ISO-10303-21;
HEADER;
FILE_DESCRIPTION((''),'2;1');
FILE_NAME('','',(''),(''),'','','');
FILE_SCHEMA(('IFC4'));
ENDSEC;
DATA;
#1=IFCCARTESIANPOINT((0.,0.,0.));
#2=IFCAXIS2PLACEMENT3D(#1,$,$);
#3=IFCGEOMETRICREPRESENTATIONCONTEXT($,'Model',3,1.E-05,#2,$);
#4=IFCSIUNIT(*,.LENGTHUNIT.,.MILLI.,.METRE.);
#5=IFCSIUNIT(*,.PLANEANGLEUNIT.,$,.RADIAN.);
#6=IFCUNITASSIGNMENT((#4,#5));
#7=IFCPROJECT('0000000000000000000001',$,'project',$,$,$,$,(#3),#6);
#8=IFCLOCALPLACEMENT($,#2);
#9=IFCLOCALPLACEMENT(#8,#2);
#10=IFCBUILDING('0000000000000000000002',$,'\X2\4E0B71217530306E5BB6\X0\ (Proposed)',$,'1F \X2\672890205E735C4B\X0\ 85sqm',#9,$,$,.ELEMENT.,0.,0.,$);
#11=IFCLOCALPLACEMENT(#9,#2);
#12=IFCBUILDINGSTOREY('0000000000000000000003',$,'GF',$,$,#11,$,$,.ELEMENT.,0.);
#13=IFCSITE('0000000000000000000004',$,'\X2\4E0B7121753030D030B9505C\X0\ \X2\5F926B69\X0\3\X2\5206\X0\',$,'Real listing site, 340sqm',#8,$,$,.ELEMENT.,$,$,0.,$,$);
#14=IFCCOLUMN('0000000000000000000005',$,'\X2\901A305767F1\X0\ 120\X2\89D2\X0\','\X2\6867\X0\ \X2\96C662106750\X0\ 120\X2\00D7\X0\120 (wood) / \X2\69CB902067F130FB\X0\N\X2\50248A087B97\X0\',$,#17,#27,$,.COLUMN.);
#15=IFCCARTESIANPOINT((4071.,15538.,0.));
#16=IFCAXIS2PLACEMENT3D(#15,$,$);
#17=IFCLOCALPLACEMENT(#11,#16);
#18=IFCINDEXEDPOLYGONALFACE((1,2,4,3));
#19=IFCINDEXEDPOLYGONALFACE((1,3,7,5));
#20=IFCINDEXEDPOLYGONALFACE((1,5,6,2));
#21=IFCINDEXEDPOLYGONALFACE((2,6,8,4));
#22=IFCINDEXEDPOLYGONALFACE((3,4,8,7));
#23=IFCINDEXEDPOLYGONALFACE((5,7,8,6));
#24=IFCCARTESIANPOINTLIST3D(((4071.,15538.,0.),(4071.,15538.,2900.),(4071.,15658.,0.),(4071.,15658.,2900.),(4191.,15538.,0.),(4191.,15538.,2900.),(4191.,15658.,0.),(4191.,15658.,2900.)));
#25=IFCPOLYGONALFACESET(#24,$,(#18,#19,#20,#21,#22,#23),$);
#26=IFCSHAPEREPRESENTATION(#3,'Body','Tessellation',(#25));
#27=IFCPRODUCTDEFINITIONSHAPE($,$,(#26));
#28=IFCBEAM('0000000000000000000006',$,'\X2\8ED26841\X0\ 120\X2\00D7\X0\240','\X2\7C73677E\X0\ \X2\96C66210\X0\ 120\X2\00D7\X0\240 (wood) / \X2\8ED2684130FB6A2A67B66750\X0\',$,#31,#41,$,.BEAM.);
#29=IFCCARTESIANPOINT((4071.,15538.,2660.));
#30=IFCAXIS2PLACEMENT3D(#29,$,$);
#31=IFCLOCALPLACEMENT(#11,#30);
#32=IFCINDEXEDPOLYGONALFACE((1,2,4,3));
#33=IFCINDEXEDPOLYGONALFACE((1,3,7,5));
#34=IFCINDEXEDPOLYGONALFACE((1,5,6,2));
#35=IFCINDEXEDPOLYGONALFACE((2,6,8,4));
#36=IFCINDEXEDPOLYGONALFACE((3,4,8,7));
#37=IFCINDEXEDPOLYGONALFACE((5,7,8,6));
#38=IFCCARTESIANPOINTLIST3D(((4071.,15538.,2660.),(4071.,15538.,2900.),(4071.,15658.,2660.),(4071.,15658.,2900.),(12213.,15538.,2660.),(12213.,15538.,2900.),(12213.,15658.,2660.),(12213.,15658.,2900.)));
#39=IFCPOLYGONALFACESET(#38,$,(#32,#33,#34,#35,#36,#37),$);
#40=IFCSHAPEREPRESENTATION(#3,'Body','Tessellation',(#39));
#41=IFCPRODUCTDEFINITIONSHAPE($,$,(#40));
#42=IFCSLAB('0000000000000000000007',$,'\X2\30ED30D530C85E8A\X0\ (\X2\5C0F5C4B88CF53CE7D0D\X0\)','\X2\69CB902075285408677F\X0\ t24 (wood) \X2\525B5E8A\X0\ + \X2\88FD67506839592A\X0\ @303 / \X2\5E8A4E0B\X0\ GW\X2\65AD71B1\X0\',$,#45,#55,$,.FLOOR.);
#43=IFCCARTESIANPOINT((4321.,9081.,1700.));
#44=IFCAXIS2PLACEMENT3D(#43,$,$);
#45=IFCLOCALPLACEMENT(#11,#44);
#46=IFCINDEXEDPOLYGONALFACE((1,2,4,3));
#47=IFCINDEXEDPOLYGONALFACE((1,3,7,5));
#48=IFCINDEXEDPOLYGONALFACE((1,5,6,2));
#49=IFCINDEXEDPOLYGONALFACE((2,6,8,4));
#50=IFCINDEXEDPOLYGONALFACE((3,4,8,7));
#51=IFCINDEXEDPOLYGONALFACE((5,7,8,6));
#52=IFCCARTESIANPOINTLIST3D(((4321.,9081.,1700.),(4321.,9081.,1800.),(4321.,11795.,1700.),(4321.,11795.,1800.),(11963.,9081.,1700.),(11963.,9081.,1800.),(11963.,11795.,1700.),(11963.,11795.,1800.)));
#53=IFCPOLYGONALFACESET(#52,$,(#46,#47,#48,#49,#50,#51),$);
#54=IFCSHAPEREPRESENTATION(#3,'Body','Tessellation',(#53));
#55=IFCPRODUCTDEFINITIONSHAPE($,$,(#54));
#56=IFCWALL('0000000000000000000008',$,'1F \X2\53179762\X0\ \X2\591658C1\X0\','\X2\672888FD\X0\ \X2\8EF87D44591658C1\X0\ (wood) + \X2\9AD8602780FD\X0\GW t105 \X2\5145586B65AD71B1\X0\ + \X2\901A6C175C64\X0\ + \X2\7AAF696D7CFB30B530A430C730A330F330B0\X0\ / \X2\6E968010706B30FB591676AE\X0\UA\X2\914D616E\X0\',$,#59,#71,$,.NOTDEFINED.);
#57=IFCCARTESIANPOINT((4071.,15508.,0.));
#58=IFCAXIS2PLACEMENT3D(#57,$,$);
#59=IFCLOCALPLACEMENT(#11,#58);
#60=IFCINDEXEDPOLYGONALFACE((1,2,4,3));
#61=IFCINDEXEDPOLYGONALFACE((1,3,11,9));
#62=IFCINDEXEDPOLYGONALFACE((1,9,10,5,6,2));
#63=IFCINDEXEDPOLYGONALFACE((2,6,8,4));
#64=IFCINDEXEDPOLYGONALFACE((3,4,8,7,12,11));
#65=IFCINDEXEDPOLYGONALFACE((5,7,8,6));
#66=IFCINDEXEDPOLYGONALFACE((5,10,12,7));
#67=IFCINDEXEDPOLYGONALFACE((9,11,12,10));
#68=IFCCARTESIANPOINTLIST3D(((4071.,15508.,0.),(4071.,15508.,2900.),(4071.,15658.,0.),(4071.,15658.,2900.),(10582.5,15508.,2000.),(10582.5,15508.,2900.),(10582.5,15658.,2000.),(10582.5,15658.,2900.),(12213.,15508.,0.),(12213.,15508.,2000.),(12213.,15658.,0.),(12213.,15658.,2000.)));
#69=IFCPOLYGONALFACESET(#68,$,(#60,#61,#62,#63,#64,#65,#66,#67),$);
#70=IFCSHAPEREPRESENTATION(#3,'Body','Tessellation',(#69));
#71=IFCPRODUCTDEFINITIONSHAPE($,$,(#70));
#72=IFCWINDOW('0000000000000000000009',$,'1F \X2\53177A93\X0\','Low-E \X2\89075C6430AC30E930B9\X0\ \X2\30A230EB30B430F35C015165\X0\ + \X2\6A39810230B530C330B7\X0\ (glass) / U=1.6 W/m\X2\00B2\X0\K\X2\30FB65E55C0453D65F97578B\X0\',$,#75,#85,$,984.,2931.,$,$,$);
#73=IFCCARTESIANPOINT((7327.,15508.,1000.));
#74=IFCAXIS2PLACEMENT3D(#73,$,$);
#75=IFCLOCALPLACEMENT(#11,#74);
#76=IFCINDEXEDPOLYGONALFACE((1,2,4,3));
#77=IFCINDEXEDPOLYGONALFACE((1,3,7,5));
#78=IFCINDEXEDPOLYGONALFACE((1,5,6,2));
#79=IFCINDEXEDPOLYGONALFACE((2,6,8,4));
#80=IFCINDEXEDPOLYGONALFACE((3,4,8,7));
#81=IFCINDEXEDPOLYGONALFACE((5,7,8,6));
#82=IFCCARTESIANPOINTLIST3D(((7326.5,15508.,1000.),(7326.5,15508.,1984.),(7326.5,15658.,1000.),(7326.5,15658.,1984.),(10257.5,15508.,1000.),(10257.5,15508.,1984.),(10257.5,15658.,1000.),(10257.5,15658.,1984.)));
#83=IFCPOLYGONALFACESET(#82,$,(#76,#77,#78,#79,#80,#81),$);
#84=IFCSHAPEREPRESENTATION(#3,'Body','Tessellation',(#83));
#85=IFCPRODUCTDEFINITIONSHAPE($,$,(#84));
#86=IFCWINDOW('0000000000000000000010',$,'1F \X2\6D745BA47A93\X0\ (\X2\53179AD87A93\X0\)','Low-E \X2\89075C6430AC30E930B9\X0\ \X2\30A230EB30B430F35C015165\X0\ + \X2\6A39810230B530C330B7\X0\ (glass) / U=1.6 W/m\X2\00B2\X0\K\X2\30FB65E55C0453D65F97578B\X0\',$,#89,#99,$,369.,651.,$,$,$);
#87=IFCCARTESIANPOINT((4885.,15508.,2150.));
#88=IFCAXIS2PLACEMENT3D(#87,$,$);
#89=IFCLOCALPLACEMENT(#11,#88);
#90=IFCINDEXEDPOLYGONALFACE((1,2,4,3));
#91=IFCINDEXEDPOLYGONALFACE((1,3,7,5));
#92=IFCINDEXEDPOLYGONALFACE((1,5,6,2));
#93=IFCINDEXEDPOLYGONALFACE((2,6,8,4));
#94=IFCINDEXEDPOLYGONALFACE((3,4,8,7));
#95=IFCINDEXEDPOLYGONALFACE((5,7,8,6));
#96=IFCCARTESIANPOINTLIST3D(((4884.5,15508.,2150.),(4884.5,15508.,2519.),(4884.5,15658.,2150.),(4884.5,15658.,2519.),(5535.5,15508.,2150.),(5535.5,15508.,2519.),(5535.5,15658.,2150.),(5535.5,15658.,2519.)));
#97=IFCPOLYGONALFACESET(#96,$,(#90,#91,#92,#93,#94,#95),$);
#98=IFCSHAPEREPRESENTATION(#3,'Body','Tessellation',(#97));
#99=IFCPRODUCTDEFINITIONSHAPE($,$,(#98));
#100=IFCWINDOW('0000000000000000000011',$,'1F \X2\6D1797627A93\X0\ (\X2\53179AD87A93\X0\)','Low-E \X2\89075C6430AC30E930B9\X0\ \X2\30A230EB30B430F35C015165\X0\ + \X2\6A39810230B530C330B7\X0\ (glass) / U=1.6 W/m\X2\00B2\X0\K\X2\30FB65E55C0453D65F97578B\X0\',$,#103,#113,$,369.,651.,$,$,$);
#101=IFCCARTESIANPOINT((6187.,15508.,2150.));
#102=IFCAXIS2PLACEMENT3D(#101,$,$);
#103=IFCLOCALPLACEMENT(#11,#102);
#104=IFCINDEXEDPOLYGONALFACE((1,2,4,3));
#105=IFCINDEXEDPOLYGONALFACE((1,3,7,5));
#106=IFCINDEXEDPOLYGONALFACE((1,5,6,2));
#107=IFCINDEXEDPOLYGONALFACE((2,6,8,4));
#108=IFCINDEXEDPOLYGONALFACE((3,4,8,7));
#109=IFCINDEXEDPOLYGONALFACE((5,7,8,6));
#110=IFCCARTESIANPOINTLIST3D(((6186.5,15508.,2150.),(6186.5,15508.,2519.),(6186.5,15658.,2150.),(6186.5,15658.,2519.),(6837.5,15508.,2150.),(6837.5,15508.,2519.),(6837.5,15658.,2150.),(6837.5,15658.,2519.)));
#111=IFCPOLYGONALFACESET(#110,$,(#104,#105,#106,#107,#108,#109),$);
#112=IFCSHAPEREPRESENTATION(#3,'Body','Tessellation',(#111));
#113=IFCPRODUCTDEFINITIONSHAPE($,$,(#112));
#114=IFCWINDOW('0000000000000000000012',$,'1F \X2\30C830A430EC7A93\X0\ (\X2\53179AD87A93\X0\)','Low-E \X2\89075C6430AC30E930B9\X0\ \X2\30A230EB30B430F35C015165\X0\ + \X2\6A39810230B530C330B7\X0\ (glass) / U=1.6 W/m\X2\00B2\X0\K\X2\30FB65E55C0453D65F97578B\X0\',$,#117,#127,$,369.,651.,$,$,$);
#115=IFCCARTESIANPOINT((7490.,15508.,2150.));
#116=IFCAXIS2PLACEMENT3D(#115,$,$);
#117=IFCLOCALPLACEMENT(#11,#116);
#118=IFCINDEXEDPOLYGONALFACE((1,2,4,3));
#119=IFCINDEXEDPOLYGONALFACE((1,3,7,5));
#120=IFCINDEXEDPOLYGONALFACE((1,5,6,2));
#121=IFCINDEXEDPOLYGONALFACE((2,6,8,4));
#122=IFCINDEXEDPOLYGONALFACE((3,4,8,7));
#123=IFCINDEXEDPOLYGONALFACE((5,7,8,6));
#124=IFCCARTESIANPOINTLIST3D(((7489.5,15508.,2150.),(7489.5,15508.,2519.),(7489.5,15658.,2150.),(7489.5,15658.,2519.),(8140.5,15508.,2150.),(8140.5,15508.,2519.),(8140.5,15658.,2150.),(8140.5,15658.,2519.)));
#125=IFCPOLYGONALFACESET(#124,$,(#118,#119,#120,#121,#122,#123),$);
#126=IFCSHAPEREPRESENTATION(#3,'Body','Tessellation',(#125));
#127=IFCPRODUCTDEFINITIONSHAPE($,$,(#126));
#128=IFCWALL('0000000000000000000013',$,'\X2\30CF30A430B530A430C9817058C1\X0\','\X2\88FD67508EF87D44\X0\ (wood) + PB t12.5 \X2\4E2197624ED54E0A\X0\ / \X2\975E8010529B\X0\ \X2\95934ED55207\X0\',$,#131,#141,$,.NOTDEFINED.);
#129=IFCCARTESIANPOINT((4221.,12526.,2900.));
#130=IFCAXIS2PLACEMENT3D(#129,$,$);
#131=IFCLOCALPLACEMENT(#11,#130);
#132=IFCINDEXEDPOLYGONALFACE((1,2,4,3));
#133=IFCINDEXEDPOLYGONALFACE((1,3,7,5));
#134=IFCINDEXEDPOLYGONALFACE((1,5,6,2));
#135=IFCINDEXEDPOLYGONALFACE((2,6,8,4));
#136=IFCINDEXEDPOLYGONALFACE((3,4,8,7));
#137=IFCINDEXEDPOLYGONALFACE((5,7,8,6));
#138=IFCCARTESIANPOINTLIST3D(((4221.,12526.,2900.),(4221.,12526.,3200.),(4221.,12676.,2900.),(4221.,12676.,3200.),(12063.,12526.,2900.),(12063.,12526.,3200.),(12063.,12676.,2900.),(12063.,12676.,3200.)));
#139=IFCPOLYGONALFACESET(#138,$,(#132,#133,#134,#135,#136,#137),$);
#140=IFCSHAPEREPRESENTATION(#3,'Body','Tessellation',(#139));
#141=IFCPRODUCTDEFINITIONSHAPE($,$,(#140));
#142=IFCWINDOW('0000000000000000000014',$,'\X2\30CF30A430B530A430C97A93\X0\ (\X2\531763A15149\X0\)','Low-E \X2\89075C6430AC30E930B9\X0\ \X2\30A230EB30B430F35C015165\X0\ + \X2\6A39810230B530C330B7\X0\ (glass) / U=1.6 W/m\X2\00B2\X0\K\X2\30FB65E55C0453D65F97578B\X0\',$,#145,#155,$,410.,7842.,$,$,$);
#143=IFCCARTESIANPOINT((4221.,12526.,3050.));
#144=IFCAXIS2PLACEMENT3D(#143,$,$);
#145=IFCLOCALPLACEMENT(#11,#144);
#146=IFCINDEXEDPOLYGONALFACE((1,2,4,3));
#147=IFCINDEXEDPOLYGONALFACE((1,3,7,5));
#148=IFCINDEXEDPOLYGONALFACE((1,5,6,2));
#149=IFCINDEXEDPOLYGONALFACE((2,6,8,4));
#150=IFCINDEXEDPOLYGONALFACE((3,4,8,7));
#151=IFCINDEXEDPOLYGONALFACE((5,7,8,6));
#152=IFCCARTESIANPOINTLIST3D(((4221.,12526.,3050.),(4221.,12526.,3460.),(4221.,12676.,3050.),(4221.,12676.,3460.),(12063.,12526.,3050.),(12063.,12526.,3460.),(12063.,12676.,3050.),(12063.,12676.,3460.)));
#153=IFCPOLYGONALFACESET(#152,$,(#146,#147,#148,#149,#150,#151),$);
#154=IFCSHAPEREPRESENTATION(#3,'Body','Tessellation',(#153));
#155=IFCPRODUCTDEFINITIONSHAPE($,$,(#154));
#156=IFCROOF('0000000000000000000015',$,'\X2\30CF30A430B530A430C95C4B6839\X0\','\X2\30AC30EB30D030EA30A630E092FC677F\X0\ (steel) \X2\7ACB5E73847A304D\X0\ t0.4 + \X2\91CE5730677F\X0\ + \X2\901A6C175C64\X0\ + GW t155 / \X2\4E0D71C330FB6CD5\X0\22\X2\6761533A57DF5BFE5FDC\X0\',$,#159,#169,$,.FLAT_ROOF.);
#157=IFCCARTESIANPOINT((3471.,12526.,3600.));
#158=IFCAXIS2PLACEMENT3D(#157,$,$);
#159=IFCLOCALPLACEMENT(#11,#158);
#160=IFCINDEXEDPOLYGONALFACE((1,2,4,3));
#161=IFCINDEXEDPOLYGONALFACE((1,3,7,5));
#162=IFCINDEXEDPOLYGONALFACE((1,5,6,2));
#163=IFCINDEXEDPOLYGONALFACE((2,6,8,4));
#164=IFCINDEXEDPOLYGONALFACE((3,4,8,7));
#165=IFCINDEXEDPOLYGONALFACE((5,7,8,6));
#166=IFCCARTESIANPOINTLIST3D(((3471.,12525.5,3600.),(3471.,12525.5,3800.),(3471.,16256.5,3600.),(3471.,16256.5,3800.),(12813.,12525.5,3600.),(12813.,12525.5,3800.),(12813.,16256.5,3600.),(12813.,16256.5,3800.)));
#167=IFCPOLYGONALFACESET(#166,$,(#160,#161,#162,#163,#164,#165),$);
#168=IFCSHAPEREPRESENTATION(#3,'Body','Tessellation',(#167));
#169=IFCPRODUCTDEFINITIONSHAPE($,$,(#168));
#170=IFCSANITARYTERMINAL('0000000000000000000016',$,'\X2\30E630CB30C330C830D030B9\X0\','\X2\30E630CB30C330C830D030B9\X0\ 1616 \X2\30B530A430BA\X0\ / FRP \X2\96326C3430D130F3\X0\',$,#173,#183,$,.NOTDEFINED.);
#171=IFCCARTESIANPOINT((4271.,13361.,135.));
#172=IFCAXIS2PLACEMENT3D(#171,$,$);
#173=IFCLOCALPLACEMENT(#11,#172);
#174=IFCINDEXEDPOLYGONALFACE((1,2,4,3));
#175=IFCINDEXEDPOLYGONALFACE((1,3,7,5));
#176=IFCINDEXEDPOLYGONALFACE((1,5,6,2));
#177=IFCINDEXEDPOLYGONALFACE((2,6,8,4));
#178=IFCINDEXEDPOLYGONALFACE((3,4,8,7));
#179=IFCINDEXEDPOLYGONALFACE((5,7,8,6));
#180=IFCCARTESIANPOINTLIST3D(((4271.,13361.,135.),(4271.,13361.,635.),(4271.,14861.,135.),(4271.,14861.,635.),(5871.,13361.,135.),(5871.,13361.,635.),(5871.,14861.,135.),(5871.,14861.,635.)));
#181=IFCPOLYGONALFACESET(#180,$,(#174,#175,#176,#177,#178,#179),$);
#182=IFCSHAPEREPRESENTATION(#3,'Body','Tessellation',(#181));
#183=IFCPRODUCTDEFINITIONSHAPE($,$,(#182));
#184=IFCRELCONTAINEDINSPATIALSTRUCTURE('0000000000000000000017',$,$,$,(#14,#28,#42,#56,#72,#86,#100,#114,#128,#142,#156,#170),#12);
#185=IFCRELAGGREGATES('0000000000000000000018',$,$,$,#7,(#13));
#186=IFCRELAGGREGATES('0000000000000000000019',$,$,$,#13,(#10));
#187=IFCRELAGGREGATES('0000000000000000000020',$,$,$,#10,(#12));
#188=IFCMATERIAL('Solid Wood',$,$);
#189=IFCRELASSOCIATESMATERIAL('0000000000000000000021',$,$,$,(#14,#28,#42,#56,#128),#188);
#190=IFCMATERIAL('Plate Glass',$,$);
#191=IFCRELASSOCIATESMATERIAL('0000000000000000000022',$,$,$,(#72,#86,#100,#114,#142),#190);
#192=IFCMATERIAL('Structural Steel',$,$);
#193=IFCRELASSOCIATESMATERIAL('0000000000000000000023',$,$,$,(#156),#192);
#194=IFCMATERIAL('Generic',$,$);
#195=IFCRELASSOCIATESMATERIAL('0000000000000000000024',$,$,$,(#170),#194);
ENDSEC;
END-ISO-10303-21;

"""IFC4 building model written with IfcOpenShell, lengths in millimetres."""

from ifc_helpers import new_model, si_unit, frame, frame_2d, origin, place, context, project, spatial, rectangle, extrude, material, element, fill, save


model = new_model("IFC4")

# Units and contexts
model_context = context("Model", 3, precision=1e-05, world=origin())
ifc_project = project(units=[si_unit("LENGTHUNIT", "METRE", prefix="MILLI"), si_unit("PLANEANGLEUNIT", "RADIAN")], contexts=[model_context])

# Site, building, storey
site_placement = place(None, origin())
site = spatial("IfcSite", under=ifc_project, at=site_placement, Name="下無田バス停 徒歩3分", ObjectType="Real listing site, 340sqm", CompositionType="ELEMENT", RefElevation=0.0)
building_placement = place(site_placement, origin())
building = spatial("IfcBuilding", under=site, at=building_placement, Name="下無田の家 (Proposed)", ObjectType="1F 木造平屋 85sqm", CompositionType="ELEMENT", ElevationOfRefHeight=0.0, ElevationOfTerrain=0.0)
storey_placement = place(building_placement, origin())
storey = spatial("IfcBuildingStorey", under=building, at=storey_placement, Name="GF", CompositionType="ELEMENT", Elevation=0.0)

# Column
ifc_material_1 = material(Name="Solid Wood")
column_1_placement = place(storey_placement, frame((4071.0, 15538.0, 0.0)))
element("IfcColumn", 1, at=column_1_placement, inside=storey, material=ifc_material_1, Name="通し柱 120角", Description="桧 集成材 120×120 (wood) / 構造柱・N値計算", PredefinedType="COLUMN", context=model_context, shape_type="SweptSolid", body=[
    extrude(rectangle(XDim=120.0, YDim=120.0, at=frame_2d((60.0, 60.0))), frame((4071.0, 15538.0, 0.0)), (0.0, 0.0, 1.0), 2900.0),
])

# Beam
beam_1_placement = place(storey_placement, frame((4071.0, 15538.0, 2660.0)))
element("IfcBeam", 2, at=beam_1_placement, inside=storey, material=ifc_material_1, Name="軒桁 120×240", Description="米松 集成 120×240 (wood) / 軒桁・横架材", PredefinedType="BEAM", context=model_context, shape_type="SweptSolid", body=[
    extrude(rectangle(XDim=8142.0, YDim=120.0, at=frame_2d((4071.0, 60.0))), frame((4071.0, 15538.0, 2660.0)), (0.0, 0.0, 1.0), 240.0),
])

# Slab
slab_placement = place(storey_placement, frame((4321.0, 9081.0, 1700.0)))
element("IfcSlab", 3, at=slab_placement, inside=storey, material=ifc_material_1, Name="ロフト床 (小屋裏収納)", Description="構造用合板 t24 (wood) 剛床 + 製材根太 @303 / 床下 GW断熱", PredefinedType="FLOOR", context=model_context, shape_type="SweptSolid", body=[
    extrude(rectangle(XDim=7642.0, YDim=2714.0, at=frame_2d((3821.0, 1357.0))), frame((4321.0, 9081.0, 1700.0)), (0.0, 0.0, 1.0), 100.0),
])

# Wall, openings, windows
wall_1_placement = place(storey_placement, frame((4071.0, 15508.0, 0.0)))
wall_1 = element("IfcWall", 4, at=wall_1_placement, inside=storey, material=ifc_material_1, Name="1F 北面 外壁", Description="木製 軸組外壁 (wood) + 高性能GW t105 充填断熱 + 通気層 + 窯業系サイディング / 準耐火・外皮UA配慮", PredefinedType="NOTDEFINED", context=model_context, shape_type="SweptSolid", body=[
    extrude(rectangle(XDim=8142.0, YDim=150.0, at=frame_2d((4071.0, 75.0))), frame((4071.0, 15508.0, 0.0)), (0.0, 0.0, 1.0), 2900.0),
])
opening_1_placement = place(storey_placement, frame((7327.0, 15508.0, 1000.0)))
opening_1 = element("IfcOpeningElement", 5, at=opening_1_placement, cuts=wall_1, PredefinedType="NOTDEFINED", context=model_context, shape_type="SweptSolid", body=[
    extrude(rectangle(XDim=2931.0, YDim=150.0, at=frame_2d((1465.0, 75.0))), frame((7327.0, 15508.0, 1000.0)), (0.0, 0.0, 1.0), 984.0),
])
opening_2_placement = place(storey_placement, frame((4885.0, 15508.0, 2150.0)))
opening_2 = element("IfcOpeningElement", 6, at=opening_2_placement, cuts=wall_1, PredefinedType="NOTDEFINED", context=model_context, shape_type="SweptSolid", body=[
    extrude(rectangle(XDim=651.0, YDim=150.0, at=frame_2d((325.0, 75.0))), frame((4885.0, 15508.0, 2150.0)), (0.0, 0.0, 1.0), 369.0),
])
opening_3_placement = place(storey_placement, frame((6187.0, 15508.0, 2150.0)))
opening_3 = element("IfcOpeningElement", 7, at=opening_3_placement, cuts=wall_1, PredefinedType="NOTDEFINED", context=model_context, shape_type="SweptSolid", body=[
    extrude(rectangle(XDim=651.0, YDim=150.0, at=frame_2d((325.0, 75.0))), frame((6187.0, 15508.0, 2150.0)), (0.0, 0.0, 1.0), 369.0),
])
opening_4_placement = place(storey_placement, frame((7490.0, 15508.0, 2150.0)))
opening_4 = element("IfcOpeningElement", 8, at=opening_4_placement, cuts=wall_1, PredefinedType="NOTDEFINED", context=model_context, shape_type="SweptSolid", body=[
    extrude(rectangle(XDim=651.0, YDim=150.0, at=frame_2d((325.0, 75.0))), frame((7490.0, 15508.0, 2150.0)), (0.0, 0.0, 1.0), 369.0),
])
ifc_material_2 = material(Name="Plate Glass")
window_1_placement = place(storey_placement, frame((7327.0, 15508.0, 1000.0)))
window_1 = element("IfcWindow", 9, at=window_1_placement, inside=storey, material=ifc_material_2, Name="1F 北窓", Description="Low-E 複層ガラス アルゴン封入 + 樹脂サッシ (glass) / U=1.6 W/m²K・日射取得型", OverallHeight=984.0, OverallWidth=2931.0, context=model_context, shape_type="SweptSolid", body=[
    extrude(rectangle(XDim=2931.0, YDim=150.0, at=frame_2d((1465.0, 75.0))), frame((7327.0, 15508.0, 1000.0)), (0.0, 0.0, 1.0), 984.0),
])
fill(opening_1, window_1)
window_2_placement = place(storey_placement, frame((4885.0, 15508.0, 2150.0)))
window_2 = element("IfcWindow", 10, at=window_2_placement, inside=storey, material=ifc_material_2, Name="1F 浴室窓 (北高窓)", Description="Low-E 複層ガラス アルゴン封入 + 樹脂サッシ (glass) / U=1.6 W/m²K・日射取得型", OverallHeight=369.0, OverallWidth=651.0, context=model_context, shape_type="SweptSolid", body=[
    extrude(rectangle(XDim=651.0, YDim=150.0, at=frame_2d((325.0, 75.0))), frame((4885.0, 15508.0, 2150.0)), (0.0, 0.0, 1.0), 369.0),
])
fill(opening_2, window_2)
window_3_placement = place(storey_placement, frame((6187.0, 15508.0, 2150.0)))
window_3 = element("IfcWindow", 11, at=window_3_placement, inside=storey, material=ifc_material_2, Name="1F 洗面窓 (北高窓)", Description="Low-E 複層ガラス アルゴン封入 + 樹脂サッシ (glass) / U=1.6 W/m²K・日射取得型", OverallHeight=369.0, OverallWidth=651.0, context=model_context, shape_type="SweptSolid", body=[
    extrude(rectangle(XDim=651.0, YDim=150.0, at=frame_2d((325.0, 75.0))), frame((6187.0, 15508.0, 2150.0)), (0.0, 0.0, 1.0), 369.0),
])
fill(opening_3, window_3)
window_4_placement = place(storey_placement, frame((7490.0, 15508.0, 2150.0)))
window_4 = element("IfcWindow", 12, at=window_4_placement, inside=storey, material=ifc_material_2, Name="1F トイレ窓 (北高窓)", Description="Low-E 複層ガラス アルゴン封入 + 樹脂サッシ (glass) / U=1.6 W/m²K・日射取得型", OverallHeight=369.0, OverallWidth=651.0, context=model_context, shape_type="SweptSolid", body=[
    extrude(rectangle(XDim=651.0, YDim=150.0, at=frame_2d((325.0, 75.0))), frame((7490.0, 15508.0, 2150.0)), (0.0, 0.0, 1.0), 369.0),
])
fill(opening_4, window_4)

# Wall, opening, window
wall_2_placement = place(storey_placement, frame((4221.0, 12526.0, 2900.0)))
wall_2 = element("IfcWall", 13, at=wall_2_placement, inside=storey, material=ifc_material_1, Name="ハイサイド腰壁", Description="製材軸組 (wood) + PB t12.5 両面仕上 / 非耐力 間仕切", PredefinedType="NOTDEFINED", context=model_context, shape_type="SweptSolid", body=[
    extrude(rectangle(XDim=7842.0, YDim=150.0, at=frame_2d((3921.0, 75.0))), frame((4221.0, 12526.0, 2900.0)), (0.0, 0.0, 1.0), 700.0),
])
opening_5_placement = place(storey_placement, frame((4221.0, 12526.0, 3050.0)))
opening_5 = element("IfcOpeningElement", 14, at=opening_5_placement, cuts=wall_2, PredefinedType="NOTDEFINED", context=model_context, shape_type="SweptSolid", body=[
    extrude(rectangle(XDim=7842.0, YDim=150.0, at=frame_2d((3921.0, 75.0))), frame((4221.0, 12526.0, 3050.0)), (0.0, 0.0, 1.0), 410.0),
])
window_5_placement = place(storey_placement, frame((4221.0, 12526.0, 3050.0)))
window_5 = element("IfcWindow", 15, at=window_5_placement, inside=storey, material=ifc_material_2, Name="ハイサイド窓 (北採光)", Description="Low-E 複層ガラス アルゴン封入 + 樹脂サッシ (glass) / U=1.6 W/m²K・日射取得型", OverallHeight=410.0, OverallWidth=7842.0, context=model_context, shape_type="SweptSolid", body=[
    extrude(rectangle(XDim=7842.0, YDim=150.0, at=frame_2d((3921.0, 75.0))), frame((4221.0, 12526.0, 3050.0)), (0.0, 0.0, 1.0), 410.0),
])
fill(opening_5, window_5)

# Roof
ifc_material_3 = material(Name="Structural Steel")
roof_placement = place(storey_placement, frame((3471.0, 12526.0, 3600.0)))
element("IfcRoof", 16, at=roof_placement, inside=storey, material=ifc_material_3, Name="ハイサイド屋根", Description="ガルバリウム鋼板 (steel) 立平葺き t0.4 + 野地板 + 通気層 + GW t155 / 不燃・法22条区域対応", PredefinedType="FLAT_ROOF", context=model_context, shape_type="SweptSolid", body=[
    extrude(rectangle(XDim=9342.0, YDim=3731.0, at=frame_2d((4671.0, 1865.0))), frame((3471.0, 12526.0, 3600.0)), (0.0, 0.0, 1.0), 200.0),
])

# Sanitary terminal
ifc_material_4 = material(Name="Generic")
sanitary_terminal_placement = place(storey_placement, frame((4271.0, 13361.0, 135.0)))
element("IfcSanitaryTerminal", 17, at=sanitary_terminal_placement, inside=storey, material=ifc_material_4, Name="ユニットバス", Description="ユニットバス 1616 サイズ / FRP 防水パン", PredefinedType="NOTDEFINED", context=model_context, shape_type="SweptSolid", body=[
    extrude(rectangle(XDim=1600.0, YDim=1500.0, at=frame_2d((800.0, 750.0))), frame((4271.0, 13361.0, 135.0)), (0.0, 0.0, 1.0), 500.0),
])

save(model, "model.ifc")
